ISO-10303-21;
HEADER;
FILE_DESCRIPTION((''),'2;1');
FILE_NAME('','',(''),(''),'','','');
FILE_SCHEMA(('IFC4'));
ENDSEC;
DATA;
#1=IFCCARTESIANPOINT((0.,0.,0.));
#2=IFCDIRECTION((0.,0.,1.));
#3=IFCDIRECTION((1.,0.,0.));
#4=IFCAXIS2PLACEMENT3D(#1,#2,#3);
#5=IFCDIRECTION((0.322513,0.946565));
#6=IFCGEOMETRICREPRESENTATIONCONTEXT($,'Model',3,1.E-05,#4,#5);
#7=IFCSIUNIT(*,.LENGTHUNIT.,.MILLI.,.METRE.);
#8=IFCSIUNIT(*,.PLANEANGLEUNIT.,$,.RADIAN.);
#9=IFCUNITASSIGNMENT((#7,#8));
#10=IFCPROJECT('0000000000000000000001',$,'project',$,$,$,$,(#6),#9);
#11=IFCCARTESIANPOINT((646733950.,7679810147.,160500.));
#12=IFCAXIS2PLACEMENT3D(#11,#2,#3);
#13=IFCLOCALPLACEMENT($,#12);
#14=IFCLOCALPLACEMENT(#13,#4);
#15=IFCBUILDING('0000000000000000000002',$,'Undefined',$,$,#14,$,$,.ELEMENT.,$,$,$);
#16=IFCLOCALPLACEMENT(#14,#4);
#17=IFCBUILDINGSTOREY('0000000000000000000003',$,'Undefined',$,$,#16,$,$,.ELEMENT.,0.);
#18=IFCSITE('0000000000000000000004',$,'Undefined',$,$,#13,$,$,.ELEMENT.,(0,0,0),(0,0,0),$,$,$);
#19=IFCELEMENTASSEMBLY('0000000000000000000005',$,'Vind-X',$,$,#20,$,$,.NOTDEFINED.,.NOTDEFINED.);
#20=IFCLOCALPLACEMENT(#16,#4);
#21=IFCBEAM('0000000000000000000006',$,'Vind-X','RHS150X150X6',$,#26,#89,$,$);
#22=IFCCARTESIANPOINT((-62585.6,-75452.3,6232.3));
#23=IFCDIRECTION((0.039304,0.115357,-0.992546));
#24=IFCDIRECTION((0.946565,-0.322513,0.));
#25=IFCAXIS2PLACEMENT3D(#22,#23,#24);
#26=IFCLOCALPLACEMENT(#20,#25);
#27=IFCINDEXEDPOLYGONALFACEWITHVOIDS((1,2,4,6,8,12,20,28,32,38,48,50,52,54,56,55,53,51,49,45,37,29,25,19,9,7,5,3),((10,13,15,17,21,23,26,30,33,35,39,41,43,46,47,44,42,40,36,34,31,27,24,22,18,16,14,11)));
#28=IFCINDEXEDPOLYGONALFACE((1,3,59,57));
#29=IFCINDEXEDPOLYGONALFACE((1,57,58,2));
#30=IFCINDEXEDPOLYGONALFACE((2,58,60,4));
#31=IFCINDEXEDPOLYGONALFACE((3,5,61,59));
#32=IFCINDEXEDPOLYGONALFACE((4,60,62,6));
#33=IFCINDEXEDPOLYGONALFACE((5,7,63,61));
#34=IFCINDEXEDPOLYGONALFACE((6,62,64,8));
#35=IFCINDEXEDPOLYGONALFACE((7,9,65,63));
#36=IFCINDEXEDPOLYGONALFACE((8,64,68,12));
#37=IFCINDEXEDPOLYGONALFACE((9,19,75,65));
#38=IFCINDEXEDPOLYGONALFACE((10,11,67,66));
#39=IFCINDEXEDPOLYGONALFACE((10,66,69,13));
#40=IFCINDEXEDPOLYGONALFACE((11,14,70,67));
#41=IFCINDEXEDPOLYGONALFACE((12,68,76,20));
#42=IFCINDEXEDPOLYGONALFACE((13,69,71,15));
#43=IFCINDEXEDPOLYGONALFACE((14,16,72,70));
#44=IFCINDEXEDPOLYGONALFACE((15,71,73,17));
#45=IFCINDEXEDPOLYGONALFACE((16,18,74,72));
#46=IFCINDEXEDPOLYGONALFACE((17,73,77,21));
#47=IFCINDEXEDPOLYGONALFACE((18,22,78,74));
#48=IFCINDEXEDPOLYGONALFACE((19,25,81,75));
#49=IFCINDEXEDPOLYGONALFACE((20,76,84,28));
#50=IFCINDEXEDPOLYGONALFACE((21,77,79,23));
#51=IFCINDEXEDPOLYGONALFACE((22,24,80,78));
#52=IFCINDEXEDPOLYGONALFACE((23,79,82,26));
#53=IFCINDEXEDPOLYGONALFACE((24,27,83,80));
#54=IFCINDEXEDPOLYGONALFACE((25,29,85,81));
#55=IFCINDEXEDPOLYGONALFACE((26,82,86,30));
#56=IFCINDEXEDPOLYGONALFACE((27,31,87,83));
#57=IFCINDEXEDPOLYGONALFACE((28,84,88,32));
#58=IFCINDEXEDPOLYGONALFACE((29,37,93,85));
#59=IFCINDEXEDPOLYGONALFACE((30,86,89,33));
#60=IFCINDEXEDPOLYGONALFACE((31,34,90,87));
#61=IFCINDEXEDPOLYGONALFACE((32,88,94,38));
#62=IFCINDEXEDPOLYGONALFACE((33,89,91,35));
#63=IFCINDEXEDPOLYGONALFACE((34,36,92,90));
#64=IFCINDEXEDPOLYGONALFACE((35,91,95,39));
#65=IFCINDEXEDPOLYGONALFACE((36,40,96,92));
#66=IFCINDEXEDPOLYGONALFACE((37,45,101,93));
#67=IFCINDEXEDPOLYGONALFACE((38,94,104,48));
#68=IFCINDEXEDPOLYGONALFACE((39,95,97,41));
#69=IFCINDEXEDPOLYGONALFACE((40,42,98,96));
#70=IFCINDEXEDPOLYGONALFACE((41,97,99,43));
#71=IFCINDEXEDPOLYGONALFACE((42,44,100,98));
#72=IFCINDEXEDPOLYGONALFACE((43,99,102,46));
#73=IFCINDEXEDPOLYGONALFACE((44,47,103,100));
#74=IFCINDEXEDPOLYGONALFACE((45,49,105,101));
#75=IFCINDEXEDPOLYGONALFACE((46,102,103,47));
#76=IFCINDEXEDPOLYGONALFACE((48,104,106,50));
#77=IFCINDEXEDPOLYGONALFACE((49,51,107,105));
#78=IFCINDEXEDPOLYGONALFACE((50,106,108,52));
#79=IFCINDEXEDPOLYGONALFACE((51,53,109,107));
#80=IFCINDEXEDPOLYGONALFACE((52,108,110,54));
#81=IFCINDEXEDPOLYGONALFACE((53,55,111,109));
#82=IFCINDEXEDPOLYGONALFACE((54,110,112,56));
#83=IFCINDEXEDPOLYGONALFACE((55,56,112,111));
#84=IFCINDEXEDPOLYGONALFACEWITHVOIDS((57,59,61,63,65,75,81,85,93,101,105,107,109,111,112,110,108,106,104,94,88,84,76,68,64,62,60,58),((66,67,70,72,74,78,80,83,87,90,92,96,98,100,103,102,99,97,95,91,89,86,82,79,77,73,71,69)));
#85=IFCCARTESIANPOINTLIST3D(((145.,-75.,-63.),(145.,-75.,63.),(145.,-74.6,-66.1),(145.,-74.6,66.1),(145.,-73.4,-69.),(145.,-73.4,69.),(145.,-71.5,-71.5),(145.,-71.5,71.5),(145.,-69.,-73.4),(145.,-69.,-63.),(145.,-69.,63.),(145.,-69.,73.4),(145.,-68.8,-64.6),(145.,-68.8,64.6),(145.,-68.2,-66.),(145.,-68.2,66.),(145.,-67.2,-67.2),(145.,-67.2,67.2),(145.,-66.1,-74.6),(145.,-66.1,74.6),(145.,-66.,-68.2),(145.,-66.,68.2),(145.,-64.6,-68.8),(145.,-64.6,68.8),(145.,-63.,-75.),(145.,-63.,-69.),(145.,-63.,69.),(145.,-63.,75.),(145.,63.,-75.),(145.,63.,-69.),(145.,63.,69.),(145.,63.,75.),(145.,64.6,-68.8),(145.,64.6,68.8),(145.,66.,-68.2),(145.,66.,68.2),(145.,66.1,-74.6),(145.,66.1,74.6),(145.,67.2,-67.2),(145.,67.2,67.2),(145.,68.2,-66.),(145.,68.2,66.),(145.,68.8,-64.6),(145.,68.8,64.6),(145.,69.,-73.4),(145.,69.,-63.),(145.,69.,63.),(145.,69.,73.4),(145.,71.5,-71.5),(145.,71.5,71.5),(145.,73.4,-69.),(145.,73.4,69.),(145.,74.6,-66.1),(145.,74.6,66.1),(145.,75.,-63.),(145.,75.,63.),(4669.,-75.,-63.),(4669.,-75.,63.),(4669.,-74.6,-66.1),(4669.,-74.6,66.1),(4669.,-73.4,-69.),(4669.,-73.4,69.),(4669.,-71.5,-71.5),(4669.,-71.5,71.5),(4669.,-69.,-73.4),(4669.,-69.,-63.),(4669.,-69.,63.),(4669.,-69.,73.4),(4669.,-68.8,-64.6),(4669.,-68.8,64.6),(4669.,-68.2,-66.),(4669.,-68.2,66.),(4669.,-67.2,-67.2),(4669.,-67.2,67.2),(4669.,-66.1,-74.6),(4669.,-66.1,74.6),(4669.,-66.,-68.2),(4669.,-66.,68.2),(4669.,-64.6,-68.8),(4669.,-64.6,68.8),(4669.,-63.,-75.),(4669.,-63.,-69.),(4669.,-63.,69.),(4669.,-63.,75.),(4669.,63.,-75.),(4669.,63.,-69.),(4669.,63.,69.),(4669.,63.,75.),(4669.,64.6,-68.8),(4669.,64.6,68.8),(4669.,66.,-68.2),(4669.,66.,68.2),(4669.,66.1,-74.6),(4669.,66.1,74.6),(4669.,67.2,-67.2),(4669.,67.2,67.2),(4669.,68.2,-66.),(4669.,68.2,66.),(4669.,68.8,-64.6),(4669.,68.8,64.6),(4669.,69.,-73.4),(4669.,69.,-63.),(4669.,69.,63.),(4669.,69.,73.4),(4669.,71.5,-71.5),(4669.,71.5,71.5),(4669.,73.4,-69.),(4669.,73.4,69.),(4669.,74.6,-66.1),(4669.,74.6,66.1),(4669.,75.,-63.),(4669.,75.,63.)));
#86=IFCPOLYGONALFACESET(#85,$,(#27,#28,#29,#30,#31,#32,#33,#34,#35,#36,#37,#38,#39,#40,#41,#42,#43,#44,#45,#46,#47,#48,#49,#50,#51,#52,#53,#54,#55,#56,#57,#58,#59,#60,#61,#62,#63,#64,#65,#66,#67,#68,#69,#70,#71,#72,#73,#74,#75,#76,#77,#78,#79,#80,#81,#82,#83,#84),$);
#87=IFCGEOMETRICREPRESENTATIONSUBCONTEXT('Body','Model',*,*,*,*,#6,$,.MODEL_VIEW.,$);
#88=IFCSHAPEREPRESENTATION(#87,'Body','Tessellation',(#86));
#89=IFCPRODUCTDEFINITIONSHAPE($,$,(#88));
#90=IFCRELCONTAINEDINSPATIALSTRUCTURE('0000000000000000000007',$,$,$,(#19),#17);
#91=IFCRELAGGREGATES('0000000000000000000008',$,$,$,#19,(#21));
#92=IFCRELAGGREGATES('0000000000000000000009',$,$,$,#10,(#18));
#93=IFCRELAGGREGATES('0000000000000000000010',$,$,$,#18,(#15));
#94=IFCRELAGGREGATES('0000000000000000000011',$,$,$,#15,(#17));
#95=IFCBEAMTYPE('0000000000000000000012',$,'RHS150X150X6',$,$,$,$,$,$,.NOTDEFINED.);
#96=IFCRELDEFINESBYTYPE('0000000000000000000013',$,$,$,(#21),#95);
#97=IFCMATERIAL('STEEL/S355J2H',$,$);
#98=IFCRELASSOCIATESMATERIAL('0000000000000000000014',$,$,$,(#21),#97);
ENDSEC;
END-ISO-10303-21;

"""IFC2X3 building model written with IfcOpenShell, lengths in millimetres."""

from ifc_helpers import new_model, si_unit, direction, frame, origin_with_axes, origin_2d_with_axis, place, context, subcontext, project, spatial, hollow_rectangle, extrude, clip, halfspace, material, type_object, element, aggregate, save


model = new_model("IFC2X3")

# Units and contexts
model_context = context("Model", 3, precision=1e-05, world=origin_with_axes(), true_north=direction((0.322513, 0.946565)))
body_context = subcontext(model_context, "Body", "Model", "MODEL_VIEW")
ifc_project = project(units=[si_unit("LENGTHUNIT", "METRE", prefix="MILLI"), si_unit("PLANEANGLEUNIT", "RADIAN")], contexts=[model_context])

# Site, building, storey
site_placement = place(None, frame((646733950.0, 7679810147.0, 160500.0), z_axis=(0.0, 0.0, 1.0), x_axis=(1.0, 0.0, 0.0)))
site = spatial("IfcSite", under=ifc_project, at=site_placement, Name="Undefined", CompositionType="ELEMENT", RefLatitude=(0, 0, 0), RefLongitude=(0, 0, 0))
building_placement = place(site_placement, origin_with_axes())
building = spatial("IfcBuilding", under=site, at=building_placement, Name="Undefined", CompositionType="ELEMENT")
storey_placement = place(building_placement, origin_with_axes())
storey = spatial("IfcBuildingStorey", under=building, at=storey_placement, Name="Undefined", CompositionType="ELEMENT", Elevation=0.0)

# Shared definitions
ifc_material_1 = material(Name="STEEL/S355J2H")

# Element assembly, beam
assembly_1_placement = place(storey_placement, origin_with_axes())
assembly_1 = element("IfcElementAssembly", 1, at=assembly_1_placement, inside=storey, Name="Vind-X", AssemblyPlace="NOTDEFINED", PredefinedType="NOTDEFINED")
beam_type_1 = type_object("IfcBeamType", Name="RHS150X150X6", PredefinedType="NOTDEFINED")
beam_1_placement = place(assembly_1_placement, frame((-62585.6, -75452.3, 6232.3), z_axis=(0.039304, 0.115357, -0.992546), x_axis=(0.946565, -0.322513, 0.0)))
beam_1 = element("IfcBeam", 2, at=beam_1_placement, type_object=beam_type_1, material=ifc_material_1, Name="Vind-X", Description="RHS150X150X6", context=body_context, shape_type="Clipping", body=[
    clip(clip(extrude(hollow_rectangle(XDim=150.0, YDim=150.0, WallThickness=6.0, InnerFilletRadius=6.0, OuterFilletRadius=12.0, at=origin_2d_with_axis()), frame((4814.0, 0.0, 0.0), z_axis=(-1.0, 0.0, 0.0), x_axis=(0.0, -1.0, 0.0)), (0.0, 0.0, 1.0), 4814.0), halfspace(frame((4669.0, 0.0, 0.0), z_axis=(-1.0, 0.0, 0.0), x_axis=(0.0, 1.0, 0.0)), True)), halfspace(frame((145.0, 0.0, 0.0), z_axis=(1.0, 0.0, 0.0), x_axis=(0.0, -1.0, 0.0)), True)),
])

aggregate(assembly_1, [beam_1])

save(model, "model.ifc")
